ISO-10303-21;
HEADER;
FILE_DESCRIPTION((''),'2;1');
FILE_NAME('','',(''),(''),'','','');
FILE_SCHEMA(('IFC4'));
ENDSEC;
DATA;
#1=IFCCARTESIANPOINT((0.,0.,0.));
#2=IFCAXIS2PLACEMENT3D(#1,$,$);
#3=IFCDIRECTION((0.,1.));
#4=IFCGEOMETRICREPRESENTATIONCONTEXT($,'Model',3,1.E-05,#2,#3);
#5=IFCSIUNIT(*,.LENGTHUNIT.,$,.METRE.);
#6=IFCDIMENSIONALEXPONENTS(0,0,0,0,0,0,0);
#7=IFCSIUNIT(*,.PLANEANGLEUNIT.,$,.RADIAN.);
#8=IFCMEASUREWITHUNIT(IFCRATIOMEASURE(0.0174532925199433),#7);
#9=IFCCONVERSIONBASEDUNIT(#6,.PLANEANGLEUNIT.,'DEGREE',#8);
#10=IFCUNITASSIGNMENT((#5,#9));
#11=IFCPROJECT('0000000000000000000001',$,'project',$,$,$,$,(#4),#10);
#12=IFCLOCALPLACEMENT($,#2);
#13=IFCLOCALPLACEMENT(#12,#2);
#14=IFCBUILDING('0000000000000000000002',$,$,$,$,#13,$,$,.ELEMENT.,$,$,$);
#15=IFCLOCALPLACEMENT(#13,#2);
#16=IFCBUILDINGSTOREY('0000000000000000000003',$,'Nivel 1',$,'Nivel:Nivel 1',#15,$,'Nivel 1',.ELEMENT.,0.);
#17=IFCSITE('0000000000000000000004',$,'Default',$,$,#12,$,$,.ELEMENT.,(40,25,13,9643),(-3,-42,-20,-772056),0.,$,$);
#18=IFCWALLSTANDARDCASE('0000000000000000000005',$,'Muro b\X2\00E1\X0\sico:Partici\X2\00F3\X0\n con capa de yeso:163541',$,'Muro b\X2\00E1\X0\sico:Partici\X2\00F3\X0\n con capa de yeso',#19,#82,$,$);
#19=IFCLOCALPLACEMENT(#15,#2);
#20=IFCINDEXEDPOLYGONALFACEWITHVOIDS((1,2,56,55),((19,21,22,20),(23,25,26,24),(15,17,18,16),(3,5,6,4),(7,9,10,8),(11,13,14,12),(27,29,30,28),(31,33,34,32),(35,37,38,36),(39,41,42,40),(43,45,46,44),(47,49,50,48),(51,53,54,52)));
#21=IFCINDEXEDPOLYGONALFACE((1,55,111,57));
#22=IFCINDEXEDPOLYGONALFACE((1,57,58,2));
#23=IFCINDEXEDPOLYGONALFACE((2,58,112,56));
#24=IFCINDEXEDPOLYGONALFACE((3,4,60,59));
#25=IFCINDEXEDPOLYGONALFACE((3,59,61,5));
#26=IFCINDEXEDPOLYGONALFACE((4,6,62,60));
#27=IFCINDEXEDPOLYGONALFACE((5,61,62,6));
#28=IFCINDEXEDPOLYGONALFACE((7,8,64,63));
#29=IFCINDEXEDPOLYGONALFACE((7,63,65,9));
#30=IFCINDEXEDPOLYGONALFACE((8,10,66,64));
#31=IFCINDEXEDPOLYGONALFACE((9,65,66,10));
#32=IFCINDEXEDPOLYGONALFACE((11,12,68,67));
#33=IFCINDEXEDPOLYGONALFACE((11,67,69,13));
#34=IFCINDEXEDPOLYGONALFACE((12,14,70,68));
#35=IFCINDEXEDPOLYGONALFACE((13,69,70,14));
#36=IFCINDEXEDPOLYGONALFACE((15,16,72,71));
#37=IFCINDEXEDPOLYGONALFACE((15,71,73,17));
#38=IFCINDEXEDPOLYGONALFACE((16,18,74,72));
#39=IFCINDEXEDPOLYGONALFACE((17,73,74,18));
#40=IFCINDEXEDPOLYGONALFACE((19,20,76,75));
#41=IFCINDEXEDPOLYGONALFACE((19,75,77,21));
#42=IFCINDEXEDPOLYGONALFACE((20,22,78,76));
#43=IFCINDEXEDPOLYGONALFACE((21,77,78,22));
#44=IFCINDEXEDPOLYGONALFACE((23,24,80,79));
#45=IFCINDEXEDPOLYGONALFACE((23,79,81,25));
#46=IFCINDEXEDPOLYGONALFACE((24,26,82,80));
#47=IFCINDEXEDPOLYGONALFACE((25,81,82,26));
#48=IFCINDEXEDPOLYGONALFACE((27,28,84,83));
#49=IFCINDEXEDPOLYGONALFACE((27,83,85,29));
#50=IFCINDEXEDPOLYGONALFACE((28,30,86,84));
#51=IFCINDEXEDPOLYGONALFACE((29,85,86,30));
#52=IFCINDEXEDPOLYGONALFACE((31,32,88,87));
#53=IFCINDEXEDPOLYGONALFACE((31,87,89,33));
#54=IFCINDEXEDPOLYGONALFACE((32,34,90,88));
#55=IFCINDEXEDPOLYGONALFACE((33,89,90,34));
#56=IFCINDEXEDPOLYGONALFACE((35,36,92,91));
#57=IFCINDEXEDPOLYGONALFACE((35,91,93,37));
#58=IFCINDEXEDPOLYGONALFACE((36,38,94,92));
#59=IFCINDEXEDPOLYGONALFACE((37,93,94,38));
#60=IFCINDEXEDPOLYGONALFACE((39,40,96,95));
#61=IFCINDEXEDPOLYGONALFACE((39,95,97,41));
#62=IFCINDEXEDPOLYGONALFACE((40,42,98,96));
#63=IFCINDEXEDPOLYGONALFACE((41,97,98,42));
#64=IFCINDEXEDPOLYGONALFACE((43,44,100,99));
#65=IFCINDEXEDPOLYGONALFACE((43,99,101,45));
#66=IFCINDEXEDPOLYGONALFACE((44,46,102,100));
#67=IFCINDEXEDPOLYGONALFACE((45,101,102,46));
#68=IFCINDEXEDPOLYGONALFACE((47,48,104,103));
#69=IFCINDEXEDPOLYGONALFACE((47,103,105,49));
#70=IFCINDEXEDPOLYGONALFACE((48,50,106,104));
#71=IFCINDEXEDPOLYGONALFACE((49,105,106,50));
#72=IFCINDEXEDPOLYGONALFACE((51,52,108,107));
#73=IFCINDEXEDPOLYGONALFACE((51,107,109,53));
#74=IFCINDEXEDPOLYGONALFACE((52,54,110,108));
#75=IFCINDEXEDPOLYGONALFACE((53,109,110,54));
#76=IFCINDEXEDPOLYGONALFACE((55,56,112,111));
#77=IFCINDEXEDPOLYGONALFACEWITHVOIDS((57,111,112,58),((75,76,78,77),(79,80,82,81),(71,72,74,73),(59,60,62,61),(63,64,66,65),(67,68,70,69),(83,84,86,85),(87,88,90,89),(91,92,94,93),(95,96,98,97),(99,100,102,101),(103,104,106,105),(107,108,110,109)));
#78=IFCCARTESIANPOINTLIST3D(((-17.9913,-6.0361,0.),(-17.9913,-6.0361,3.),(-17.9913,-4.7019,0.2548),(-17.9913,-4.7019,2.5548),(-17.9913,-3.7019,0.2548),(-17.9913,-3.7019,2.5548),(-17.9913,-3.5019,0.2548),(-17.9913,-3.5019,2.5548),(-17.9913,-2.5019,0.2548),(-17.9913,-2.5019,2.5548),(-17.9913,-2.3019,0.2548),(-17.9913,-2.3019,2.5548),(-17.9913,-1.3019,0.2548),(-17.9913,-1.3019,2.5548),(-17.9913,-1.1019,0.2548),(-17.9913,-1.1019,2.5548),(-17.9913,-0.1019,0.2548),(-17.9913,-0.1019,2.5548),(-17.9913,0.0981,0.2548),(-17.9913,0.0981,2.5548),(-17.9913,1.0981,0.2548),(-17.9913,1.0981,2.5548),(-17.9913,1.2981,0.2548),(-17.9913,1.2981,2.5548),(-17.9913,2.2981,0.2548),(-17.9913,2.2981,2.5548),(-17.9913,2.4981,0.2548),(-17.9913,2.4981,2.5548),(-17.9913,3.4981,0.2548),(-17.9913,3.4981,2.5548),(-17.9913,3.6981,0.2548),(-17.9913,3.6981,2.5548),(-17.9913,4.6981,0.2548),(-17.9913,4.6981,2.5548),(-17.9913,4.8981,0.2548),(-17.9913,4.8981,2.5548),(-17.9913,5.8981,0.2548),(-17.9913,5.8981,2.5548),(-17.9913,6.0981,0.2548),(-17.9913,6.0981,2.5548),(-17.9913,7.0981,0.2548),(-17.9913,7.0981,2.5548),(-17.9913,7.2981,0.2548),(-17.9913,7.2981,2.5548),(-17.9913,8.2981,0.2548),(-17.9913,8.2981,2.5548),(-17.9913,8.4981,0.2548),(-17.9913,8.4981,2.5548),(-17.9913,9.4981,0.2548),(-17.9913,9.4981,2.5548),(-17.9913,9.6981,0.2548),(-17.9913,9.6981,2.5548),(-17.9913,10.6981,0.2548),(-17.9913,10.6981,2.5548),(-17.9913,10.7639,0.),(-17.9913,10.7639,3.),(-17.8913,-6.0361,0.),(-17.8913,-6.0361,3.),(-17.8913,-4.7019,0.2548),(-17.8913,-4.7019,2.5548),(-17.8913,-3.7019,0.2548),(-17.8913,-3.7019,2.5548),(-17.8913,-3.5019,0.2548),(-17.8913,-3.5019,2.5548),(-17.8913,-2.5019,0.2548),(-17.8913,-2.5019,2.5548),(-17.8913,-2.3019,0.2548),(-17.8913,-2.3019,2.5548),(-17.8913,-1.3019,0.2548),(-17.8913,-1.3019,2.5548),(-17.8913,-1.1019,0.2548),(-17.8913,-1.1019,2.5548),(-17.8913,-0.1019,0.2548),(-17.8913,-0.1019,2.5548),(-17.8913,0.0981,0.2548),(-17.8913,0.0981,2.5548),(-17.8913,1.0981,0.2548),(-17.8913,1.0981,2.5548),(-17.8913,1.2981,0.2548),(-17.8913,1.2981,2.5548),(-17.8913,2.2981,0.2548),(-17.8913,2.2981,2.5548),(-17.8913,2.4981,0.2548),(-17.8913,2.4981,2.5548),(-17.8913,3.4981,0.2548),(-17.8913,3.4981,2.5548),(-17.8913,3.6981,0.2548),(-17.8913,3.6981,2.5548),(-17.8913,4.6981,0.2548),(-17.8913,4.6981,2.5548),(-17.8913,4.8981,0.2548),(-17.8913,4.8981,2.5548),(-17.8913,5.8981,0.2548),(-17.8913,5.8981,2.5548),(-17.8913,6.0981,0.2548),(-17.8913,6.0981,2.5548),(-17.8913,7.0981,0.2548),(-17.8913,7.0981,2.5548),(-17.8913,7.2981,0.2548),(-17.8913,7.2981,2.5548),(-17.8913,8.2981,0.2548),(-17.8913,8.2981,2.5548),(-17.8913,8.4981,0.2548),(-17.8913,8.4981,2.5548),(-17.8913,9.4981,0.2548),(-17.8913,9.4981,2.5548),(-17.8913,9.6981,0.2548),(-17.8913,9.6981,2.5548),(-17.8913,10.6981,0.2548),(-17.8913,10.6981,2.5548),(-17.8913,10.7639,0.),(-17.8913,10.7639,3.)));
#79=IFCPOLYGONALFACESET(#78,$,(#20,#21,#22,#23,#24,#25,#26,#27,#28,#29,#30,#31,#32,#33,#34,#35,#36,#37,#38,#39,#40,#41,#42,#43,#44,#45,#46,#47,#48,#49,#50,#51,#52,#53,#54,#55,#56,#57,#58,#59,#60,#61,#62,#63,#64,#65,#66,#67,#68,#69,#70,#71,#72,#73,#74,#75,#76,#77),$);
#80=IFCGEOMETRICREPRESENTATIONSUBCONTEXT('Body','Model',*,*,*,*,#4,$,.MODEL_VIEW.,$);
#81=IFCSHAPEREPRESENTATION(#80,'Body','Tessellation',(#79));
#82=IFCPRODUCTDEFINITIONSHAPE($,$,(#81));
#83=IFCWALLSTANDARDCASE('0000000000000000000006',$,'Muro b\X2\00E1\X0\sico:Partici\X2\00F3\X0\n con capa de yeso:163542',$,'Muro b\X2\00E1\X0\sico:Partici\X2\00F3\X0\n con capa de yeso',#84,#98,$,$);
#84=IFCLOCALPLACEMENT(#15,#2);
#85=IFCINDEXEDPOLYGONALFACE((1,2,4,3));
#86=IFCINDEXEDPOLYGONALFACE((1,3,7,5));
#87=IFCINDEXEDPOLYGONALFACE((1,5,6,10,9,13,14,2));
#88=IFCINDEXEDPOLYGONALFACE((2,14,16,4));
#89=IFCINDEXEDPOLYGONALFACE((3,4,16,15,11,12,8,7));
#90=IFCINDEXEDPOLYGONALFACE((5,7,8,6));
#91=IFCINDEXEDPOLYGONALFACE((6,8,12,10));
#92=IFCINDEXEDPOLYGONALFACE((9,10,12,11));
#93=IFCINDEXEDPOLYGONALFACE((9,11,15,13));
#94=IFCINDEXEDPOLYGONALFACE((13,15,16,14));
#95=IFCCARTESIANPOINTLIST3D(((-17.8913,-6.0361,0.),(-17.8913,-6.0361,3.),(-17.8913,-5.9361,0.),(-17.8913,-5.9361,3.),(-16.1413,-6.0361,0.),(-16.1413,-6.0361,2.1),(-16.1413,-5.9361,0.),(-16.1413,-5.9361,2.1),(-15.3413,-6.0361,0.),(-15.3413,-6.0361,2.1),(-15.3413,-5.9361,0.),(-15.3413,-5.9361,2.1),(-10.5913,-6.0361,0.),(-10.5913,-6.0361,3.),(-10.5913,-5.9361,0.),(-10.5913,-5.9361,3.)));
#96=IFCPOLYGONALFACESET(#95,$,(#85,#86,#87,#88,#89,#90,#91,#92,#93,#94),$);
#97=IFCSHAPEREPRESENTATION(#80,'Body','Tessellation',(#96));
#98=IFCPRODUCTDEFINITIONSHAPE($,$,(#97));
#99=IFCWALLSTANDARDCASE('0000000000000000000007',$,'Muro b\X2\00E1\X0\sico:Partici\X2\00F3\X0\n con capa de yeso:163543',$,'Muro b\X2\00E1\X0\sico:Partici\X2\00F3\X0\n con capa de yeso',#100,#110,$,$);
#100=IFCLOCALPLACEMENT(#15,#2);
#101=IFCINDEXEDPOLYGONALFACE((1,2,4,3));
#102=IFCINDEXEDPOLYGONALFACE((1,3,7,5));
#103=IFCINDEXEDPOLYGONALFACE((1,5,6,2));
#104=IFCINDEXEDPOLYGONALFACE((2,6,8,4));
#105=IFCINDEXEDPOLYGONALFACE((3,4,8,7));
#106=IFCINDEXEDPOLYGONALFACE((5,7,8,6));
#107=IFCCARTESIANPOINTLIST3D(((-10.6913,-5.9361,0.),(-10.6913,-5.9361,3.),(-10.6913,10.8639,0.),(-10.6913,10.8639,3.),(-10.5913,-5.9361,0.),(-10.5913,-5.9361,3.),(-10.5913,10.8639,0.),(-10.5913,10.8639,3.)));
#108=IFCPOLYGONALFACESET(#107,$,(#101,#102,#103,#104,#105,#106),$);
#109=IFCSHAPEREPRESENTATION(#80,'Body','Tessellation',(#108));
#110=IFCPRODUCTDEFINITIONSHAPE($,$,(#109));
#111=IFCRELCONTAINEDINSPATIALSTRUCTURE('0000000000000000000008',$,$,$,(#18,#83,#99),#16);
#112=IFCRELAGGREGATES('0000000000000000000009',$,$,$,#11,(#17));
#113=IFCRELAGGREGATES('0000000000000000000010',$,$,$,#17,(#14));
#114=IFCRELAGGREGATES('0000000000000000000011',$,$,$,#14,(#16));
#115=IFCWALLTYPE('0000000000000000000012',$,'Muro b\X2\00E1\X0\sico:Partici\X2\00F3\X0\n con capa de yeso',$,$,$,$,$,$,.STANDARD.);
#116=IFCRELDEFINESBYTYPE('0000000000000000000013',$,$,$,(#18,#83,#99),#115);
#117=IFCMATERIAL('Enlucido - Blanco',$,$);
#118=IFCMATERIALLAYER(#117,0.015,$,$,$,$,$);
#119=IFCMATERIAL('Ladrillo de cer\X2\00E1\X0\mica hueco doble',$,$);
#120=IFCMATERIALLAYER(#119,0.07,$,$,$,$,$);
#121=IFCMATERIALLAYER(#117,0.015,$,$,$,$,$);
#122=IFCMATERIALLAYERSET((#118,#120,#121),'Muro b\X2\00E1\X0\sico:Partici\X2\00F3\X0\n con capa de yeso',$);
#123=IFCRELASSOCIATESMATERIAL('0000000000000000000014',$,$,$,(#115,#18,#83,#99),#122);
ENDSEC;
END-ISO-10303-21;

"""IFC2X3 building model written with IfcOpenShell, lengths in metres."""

from ifc_helpers import new_model, entity, si_unit, converted_unit, direction, frame, frame_2d, origin, place, context, subcontext, project, spatial, rectangle, extrude, material, layer, layer_set, layer_usage, type_object, element, save


model = new_model("IFC2X3")

# Units and contexts
model_context = context("Model", 3, precision=1e-05, world=origin(), true_north=direction((0.0, 1.0)))
body_context = subcontext(model_context, "Body", "Model", "MODEL_VIEW")
ifc_project = project(units=[si_unit("LENGTHUNIT", "METRE"), converted_unit("PLANEANGLEUNIT", "DEGREE", entity("IfcRatioMeasure", 0.0174532925199433), si_unit("PLANEANGLEUNIT", "RADIAN"), dimensions=[0, 0, 0, 0, 0, 0, 0])], contexts=[model_context])

# Site, building, storey
site_placement = place(None, origin())
site = spatial("IfcSite", under=ifc_project, at=site_placement, Name="Default", CompositionType="ELEMENT", RefLatitude=(40, 25, 13, 9643), RefLongitude=(-3, -42, -20, -772056), RefElevation=0.0)
building_placement = place(site_placement, origin())
building = spatial("IfcBuilding", under=site, at=building_placement, CompositionType="ELEMENT")
storey_placement = place(building_placement, origin())
storey = spatial("IfcBuildingStorey", under=building, at=storey_placement, Name="Nivel 1", ObjectType="Nivel:Nivel 1", LongName="Nivel 1", CompositionType="ELEMENT", Elevation=0.0)

# Wall, openings
ifc_material_1 = material(Name="Enlucido - Blanco")
ifc_layer_1 = layer(ifc_material_1, 0.015)
ifc_material_2 = material(Name="Ladrillo de cerámica hueco doble")
ifc_layer_2 = layer(ifc_material_2, 0.07)
ifc_layer_3 = layer(ifc_material_1, 0.015)
ifc_layer_set_1 = layer_set([ifc_layer_1, ifc_layer_2, ifc_layer_3], Name="Muro básico:Partición con capa de yeso")
wall_type = type_object("IfcWallType", Name="Muro básico:Partición con capa de yeso", PredefinedType="STANDARD", material=ifc_layer_set_1)
ifc_layer_usage_1 = layer_usage(ifc_layer_set_1, "AXIS2", "NEGATIVE", 0.05)
wall_1_placement = place(storey_placement, frame((-17.9413, -6.0361, 0.0), z_axis=(0.0, 0.0, 1.0), x_axis=(0.0, 1.0, 0.0)))
wall_1 = element("IfcWallStandardCase", 1, at=wall_1_placement, inside=storey, type_object=wall_type, material=ifc_layer_usage_1, Name="Muro básico:Partición con capa de yeso:163541", ObjectType="Muro básico:Partición con capa de yeso", context=body_context, shape_type="SweptSolid", body=[
    extrude(rectangle(XDim=16.8, YDim=0.1, at=frame_2d((8.4, 0.0), x_axis=(-1.0, 0.0))), origin(), (0.0, 0.0, 1.0), 3.0),
])
opening_1_placement = place(wall_1_placement, frame((15.7342, -0.05, 0.2548)))
element("IfcOpeningElement", 2, at=opening_1_placement, cuts=wall_1, ObjectType="Opening", context=body_context, shape_type="SweptSolid", body=[
    extrude(rectangle(XDim=2.3, YDim=1.0, at=frame_2d((1.15, 0.5), x_axis=(1.0, 0.0))), frame((0.0, 0.0, 0.0), z_axis=(0.0, 1.0, 0.0), x_axis=(0.0, 0.0, 1.0)), (0.0, 0.0, 1.0), 0.1),
])
opening_2_placement = place(wall_1_placement, frame((14.5342, -0.05, 0.2548)))
element("IfcOpeningElement", 3, at=opening_2_placement, cuts=wall_1, ObjectType="Opening", context=body_context, shape_type="SweptSolid", body=[
    extrude(rectangle(XDim=2.3, YDim=1.0, at=frame_2d((1.15, 0.5), x_axis=(1.0, 0.0))), frame((0.0, 0.0, 0.0), z_axis=(0.0, 1.0, 0.0), x_axis=(0.0, 0.0, 1.0)), (0.0, 0.0, 1.0), 0.1),
])
opening_3_placement = place(wall_1_placement, frame((13.3342, -0.05, 0.2548)))
element("IfcOpeningElement", 4, at=opening_3_placement, cuts=wall_1, ObjectType="Opening", context=body_context, shape_type="SweptSolid", body=[
    extrude(rectangle(XDim=2.3, YDim=1.0, at=frame_2d((1.15, 0.5), x_axis=(1.0, 0.0))), frame((0.0, 0.0, 0.0), z_axis=(0.0, 1.0, 0.0), x_axis=(0.0, 0.0, 1.0)), (0.0, 0.0, 1.0), 0.1),
])
opening_4_placement = place(wall_1_placement, frame((12.1342, -0.05, 0.2548)))
element("IfcOpeningElement", 5, at=opening_4_placement, cuts=wall_1, ObjectType="Opening", context=body_context, shape_type="SweptSolid", body=[
    extrude(rectangle(XDim=2.3, YDim=1.0, at=frame_2d((1.15, 0.5), x_axis=(1.0, 0.0))), frame((0.0, 0.0, 0.0), z_axis=(0.0, 1.0, 0.0), x_axis=(0.0, 0.0, 1.0)), (0.0, 0.0, 1.0), 0.1),
])
opening_5_placement = place(wall_1_placement, frame((10.9342, -0.05, 0.2548)))
element("IfcOpeningElement", 6, at=opening_5_placement, cuts=wall_1, ObjectType="Opening", context=body_context, shape_type="SweptSolid", body=[
    extrude(rectangle(XDim=2.3, YDim=1.0, at=frame_2d((1.15, 0.5), x_axis=(1.0, 0.0))), frame((0.0, 0.0, 0.0), z_axis=(0.0, 1.0, 0.0), x_axis=(0.0, 0.0, 1.0)), (0.0, 0.0, 1.0), 0.1),
])
opening_6_placement = place(wall_1_placement, frame((9.7342, -0.05, 0.2548)))
element("IfcOpeningElement", 7, at=opening_6_placement, cuts=wall_1, ObjectType="Opening", context=body_context, shape_type="SweptSolid", body=[
    extrude(rectangle(XDim=2.3, YDim=1.0, at=frame_2d((1.15, 0.5), x_axis=(1.0, 0.0))), frame((0.0, 0.0, 0.0), z_axis=(0.0, 1.0, 0.0), x_axis=(0.0, 0.0, 1.0)), (0.0, 0.0, 1.0), 0.1),
])
opening_7_placement = place(wall_1_placement, frame((8.5342, -0.05, 0.2548)))
element("IfcOpeningElement", 8, at=opening_7_placement, cuts=wall_1, ObjectType="Opening", context=body_context, shape_type="SweptSolid", body=[
    extrude(rectangle(XDim=2.3, YDim=1.0, at=frame_2d((1.15, 0.5), x_axis=(1.0, 0.0))), frame((0.0, 0.0, 0.0), z_axis=(0.0, 1.0, 0.0), x_axis=(0.0, 0.0, 1.0)), (0.0, 0.0, 1.0), 0.1),
])
opening_8_placement = place(wall_1_placement, frame((7.3342, -0.05, 0.2548)))
element("IfcOpeningElement", 9, at=opening_8_placement, cuts=wall_1, ObjectType="Opening", context=body_context, shape_type="SweptSolid", body=[
    extrude(rectangle(XDim=2.3, YDim=1.0, at=frame_2d((1.15, 0.5), x_axis=(1.0, 0.0))), frame((0.0, 0.0, 0.0), z_axis=(0.0, 1.0, 0.0), x_axis=(0.0, 0.0, 1.0)), (0.0, 0.0, 1.0), 0.1),
])
opening_9_placement = place(wall_1_placement, frame((6.1342, -0.05, 0.2548)))
element("IfcOpeningElement", 10, at=opening_9_placement, cuts=wall_1, ObjectType="Opening", context=body_context, shape_type="SweptSolid", body=[
    extrude(rectangle(XDim=2.3, YDim=1.0, at=frame_2d((1.15, 0.5), x_axis=(1.0, 0.0))), frame((0.0, 0.0, 0.0), z_axis=(0.0, 1.0, 0.0), x_axis=(0.0, 0.0, 1.0)), (0.0, 0.0, 1.0), 0.1),
])
opening_10_placement = place(wall_1_placement, frame((4.9342, -0.05, 0.2548)))
element("IfcOpeningElement", 11, at=opening_10_placement, cuts=wall_1, ObjectType="Opening", context=body_context, shape_type="SweptSolid", body=[
    extrude(rectangle(XDim=2.3, YDim=1.0, at=frame_2d((1.15, 0.5), x_axis=(1.0, 0.0))), frame((0.0, 0.0, 0.0), z_axis=(0.0, 1.0, 0.0), x_axis=(0.0, 0.0, 1.0)), (0.0, 0.0, 1.0), 0.1),
])
opening_11_placement = place(wall_1_placement, frame((3.7342, -0.05, 0.2548)))
element("IfcOpeningElement", 12, at=opening_11_placement, cuts=wall_1, ObjectType="Opening", context=body_context, shape_type="SweptSolid", body=[
    extrude(rectangle(XDim=2.3, YDim=1.0, at=frame_2d((1.15, 0.5), x_axis=(1.0, 0.0))), frame((0.0, 0.0, 0.0), z_axis=(0.0, 1.0, 0.0), x_axis=(0.0, 0.0, 1.0)), (0.0, 0.0, 1.0), 0.1),
])
opening_12_placement = place(wall_1_placement, frame((2.5342, -0.05, 0.2548)))
element("IfcOpeningElement", 13, at=opening_12_placement, cuts=wall_1, ObjectType="Opening", context=body_context, shape_type="SweptSolid", body=[
    extrude(rectangle(XDim=2.3, YDim=1.0, at=frame_2d((1.15, 0.5), x_axis=(1.0, 0.0))), frame((0.0, 0.0, 0.0), z_axis=(0.0, 1.0, 0.0), x_axis=(0.0, 0.0, 1.0)), (0.0, 0.0, 1.0), 0.1),
])
opening_13_placement = place(wall_1_placement, frame((1.3342, -0.05, 0.2548)))
element("IfcOpeningElement", 14, at=opening_13_placement, cuts=wall_1, ObjectType="Opening", context=body_context, shape_type="SweptSolid", body=[
    extrude(rectangle(XDim=2.3, YDim=1.0, at=frame_2d((1.15, 0.5), x_axis=(1.0, 0.0))), frame((0.0, 0.0, 0.0), z_axis=(0.0, 1.0, 0.0), x_axis=(0.0, 0.0, 1.0)), (0.0, 0.0, 1.0), 0.1),
])

# Wall, opening
ifc_layer_usage_2 = layer_usage(ifc_layer_set_1, "AXIS2", "NEGATIVE", 0.05)
wall_2_placement = place(storey_placement, frame((-10.5913, -5.9861, 0.0), z_axis=(0.0, 0.0, 1.0), x_axis=(-1.0, 0.0, 0.0)))
wall_2 = element("IfcWallStandardCase", 15, at=wall_2_placement, inside=storey, type_object=wall_type, material=ifc_layer_usage_2, Name="Muro básico:Partición con capa de yeso:163542", ObjectType="Muro básico:Partición con capa de yeso", context=body_context, shape_type="SweptSolid", body=[
    extrude(rectangle(XDim=7.3, YDim=0.1, at=frame_2d((3.65, 0.0), x_axis=(-1.0, 0.0))), origin(), (0.0, 0.0, 1.0), 3.0),
])
opening_14_placement = place(wall_2_placement, frame((5.55, 0.05, 0.0)))
element("IfcOpeningElement", 16, at=opening_14_placement, cuts=wall_2, ObjectType="Opening", context=body_context, shape_type="SweptSolid", body=[
    extrude(rectangle(XDim=2.1, YDim=0.8, at=frame_2d((1.05, 0.4), x_axis=(1.0, 0.0))), frame((0.0, 0.0, 0.0), z_axis=(0.0, -1.0, 0.0), x_axis=(0.0, 0.0, 1.0)), (0.0, 0.0, 1.0), 0.1),
])

# Wall
ifc_layer_usage_3 = layer_usage(ifc_layer_set_1, "AXIS2", "NEGATIVE", 0.05)
wall_3_placement = place(storey_placement, frame((-10.6413, 10.8639, 0.0), z_axis=(0.0, 0.0, 1.0), x_axis=(0.0, -1.0, 0.0)))
element("IfcWallStandardCase", 17, at=wall_3_placement, inside=storey, type_object=wall_type, material=ifc_layer_usage_3, Name="Muro básico:Partición con capa de yeso:163543", ObjectType="Muro básico:Partición con capa de yeso", context=body_context, shape_type="SweptSolid", body=[
    extrude(rectangle(XDim=16.8, YDim=0.1, at=frame_2d((8.4, 0.0), x_axis=(-1.0, 0.0))), origin(), (0.0, 0.0, 1.0), 3.0),
])

save(model, "model.ifc")
